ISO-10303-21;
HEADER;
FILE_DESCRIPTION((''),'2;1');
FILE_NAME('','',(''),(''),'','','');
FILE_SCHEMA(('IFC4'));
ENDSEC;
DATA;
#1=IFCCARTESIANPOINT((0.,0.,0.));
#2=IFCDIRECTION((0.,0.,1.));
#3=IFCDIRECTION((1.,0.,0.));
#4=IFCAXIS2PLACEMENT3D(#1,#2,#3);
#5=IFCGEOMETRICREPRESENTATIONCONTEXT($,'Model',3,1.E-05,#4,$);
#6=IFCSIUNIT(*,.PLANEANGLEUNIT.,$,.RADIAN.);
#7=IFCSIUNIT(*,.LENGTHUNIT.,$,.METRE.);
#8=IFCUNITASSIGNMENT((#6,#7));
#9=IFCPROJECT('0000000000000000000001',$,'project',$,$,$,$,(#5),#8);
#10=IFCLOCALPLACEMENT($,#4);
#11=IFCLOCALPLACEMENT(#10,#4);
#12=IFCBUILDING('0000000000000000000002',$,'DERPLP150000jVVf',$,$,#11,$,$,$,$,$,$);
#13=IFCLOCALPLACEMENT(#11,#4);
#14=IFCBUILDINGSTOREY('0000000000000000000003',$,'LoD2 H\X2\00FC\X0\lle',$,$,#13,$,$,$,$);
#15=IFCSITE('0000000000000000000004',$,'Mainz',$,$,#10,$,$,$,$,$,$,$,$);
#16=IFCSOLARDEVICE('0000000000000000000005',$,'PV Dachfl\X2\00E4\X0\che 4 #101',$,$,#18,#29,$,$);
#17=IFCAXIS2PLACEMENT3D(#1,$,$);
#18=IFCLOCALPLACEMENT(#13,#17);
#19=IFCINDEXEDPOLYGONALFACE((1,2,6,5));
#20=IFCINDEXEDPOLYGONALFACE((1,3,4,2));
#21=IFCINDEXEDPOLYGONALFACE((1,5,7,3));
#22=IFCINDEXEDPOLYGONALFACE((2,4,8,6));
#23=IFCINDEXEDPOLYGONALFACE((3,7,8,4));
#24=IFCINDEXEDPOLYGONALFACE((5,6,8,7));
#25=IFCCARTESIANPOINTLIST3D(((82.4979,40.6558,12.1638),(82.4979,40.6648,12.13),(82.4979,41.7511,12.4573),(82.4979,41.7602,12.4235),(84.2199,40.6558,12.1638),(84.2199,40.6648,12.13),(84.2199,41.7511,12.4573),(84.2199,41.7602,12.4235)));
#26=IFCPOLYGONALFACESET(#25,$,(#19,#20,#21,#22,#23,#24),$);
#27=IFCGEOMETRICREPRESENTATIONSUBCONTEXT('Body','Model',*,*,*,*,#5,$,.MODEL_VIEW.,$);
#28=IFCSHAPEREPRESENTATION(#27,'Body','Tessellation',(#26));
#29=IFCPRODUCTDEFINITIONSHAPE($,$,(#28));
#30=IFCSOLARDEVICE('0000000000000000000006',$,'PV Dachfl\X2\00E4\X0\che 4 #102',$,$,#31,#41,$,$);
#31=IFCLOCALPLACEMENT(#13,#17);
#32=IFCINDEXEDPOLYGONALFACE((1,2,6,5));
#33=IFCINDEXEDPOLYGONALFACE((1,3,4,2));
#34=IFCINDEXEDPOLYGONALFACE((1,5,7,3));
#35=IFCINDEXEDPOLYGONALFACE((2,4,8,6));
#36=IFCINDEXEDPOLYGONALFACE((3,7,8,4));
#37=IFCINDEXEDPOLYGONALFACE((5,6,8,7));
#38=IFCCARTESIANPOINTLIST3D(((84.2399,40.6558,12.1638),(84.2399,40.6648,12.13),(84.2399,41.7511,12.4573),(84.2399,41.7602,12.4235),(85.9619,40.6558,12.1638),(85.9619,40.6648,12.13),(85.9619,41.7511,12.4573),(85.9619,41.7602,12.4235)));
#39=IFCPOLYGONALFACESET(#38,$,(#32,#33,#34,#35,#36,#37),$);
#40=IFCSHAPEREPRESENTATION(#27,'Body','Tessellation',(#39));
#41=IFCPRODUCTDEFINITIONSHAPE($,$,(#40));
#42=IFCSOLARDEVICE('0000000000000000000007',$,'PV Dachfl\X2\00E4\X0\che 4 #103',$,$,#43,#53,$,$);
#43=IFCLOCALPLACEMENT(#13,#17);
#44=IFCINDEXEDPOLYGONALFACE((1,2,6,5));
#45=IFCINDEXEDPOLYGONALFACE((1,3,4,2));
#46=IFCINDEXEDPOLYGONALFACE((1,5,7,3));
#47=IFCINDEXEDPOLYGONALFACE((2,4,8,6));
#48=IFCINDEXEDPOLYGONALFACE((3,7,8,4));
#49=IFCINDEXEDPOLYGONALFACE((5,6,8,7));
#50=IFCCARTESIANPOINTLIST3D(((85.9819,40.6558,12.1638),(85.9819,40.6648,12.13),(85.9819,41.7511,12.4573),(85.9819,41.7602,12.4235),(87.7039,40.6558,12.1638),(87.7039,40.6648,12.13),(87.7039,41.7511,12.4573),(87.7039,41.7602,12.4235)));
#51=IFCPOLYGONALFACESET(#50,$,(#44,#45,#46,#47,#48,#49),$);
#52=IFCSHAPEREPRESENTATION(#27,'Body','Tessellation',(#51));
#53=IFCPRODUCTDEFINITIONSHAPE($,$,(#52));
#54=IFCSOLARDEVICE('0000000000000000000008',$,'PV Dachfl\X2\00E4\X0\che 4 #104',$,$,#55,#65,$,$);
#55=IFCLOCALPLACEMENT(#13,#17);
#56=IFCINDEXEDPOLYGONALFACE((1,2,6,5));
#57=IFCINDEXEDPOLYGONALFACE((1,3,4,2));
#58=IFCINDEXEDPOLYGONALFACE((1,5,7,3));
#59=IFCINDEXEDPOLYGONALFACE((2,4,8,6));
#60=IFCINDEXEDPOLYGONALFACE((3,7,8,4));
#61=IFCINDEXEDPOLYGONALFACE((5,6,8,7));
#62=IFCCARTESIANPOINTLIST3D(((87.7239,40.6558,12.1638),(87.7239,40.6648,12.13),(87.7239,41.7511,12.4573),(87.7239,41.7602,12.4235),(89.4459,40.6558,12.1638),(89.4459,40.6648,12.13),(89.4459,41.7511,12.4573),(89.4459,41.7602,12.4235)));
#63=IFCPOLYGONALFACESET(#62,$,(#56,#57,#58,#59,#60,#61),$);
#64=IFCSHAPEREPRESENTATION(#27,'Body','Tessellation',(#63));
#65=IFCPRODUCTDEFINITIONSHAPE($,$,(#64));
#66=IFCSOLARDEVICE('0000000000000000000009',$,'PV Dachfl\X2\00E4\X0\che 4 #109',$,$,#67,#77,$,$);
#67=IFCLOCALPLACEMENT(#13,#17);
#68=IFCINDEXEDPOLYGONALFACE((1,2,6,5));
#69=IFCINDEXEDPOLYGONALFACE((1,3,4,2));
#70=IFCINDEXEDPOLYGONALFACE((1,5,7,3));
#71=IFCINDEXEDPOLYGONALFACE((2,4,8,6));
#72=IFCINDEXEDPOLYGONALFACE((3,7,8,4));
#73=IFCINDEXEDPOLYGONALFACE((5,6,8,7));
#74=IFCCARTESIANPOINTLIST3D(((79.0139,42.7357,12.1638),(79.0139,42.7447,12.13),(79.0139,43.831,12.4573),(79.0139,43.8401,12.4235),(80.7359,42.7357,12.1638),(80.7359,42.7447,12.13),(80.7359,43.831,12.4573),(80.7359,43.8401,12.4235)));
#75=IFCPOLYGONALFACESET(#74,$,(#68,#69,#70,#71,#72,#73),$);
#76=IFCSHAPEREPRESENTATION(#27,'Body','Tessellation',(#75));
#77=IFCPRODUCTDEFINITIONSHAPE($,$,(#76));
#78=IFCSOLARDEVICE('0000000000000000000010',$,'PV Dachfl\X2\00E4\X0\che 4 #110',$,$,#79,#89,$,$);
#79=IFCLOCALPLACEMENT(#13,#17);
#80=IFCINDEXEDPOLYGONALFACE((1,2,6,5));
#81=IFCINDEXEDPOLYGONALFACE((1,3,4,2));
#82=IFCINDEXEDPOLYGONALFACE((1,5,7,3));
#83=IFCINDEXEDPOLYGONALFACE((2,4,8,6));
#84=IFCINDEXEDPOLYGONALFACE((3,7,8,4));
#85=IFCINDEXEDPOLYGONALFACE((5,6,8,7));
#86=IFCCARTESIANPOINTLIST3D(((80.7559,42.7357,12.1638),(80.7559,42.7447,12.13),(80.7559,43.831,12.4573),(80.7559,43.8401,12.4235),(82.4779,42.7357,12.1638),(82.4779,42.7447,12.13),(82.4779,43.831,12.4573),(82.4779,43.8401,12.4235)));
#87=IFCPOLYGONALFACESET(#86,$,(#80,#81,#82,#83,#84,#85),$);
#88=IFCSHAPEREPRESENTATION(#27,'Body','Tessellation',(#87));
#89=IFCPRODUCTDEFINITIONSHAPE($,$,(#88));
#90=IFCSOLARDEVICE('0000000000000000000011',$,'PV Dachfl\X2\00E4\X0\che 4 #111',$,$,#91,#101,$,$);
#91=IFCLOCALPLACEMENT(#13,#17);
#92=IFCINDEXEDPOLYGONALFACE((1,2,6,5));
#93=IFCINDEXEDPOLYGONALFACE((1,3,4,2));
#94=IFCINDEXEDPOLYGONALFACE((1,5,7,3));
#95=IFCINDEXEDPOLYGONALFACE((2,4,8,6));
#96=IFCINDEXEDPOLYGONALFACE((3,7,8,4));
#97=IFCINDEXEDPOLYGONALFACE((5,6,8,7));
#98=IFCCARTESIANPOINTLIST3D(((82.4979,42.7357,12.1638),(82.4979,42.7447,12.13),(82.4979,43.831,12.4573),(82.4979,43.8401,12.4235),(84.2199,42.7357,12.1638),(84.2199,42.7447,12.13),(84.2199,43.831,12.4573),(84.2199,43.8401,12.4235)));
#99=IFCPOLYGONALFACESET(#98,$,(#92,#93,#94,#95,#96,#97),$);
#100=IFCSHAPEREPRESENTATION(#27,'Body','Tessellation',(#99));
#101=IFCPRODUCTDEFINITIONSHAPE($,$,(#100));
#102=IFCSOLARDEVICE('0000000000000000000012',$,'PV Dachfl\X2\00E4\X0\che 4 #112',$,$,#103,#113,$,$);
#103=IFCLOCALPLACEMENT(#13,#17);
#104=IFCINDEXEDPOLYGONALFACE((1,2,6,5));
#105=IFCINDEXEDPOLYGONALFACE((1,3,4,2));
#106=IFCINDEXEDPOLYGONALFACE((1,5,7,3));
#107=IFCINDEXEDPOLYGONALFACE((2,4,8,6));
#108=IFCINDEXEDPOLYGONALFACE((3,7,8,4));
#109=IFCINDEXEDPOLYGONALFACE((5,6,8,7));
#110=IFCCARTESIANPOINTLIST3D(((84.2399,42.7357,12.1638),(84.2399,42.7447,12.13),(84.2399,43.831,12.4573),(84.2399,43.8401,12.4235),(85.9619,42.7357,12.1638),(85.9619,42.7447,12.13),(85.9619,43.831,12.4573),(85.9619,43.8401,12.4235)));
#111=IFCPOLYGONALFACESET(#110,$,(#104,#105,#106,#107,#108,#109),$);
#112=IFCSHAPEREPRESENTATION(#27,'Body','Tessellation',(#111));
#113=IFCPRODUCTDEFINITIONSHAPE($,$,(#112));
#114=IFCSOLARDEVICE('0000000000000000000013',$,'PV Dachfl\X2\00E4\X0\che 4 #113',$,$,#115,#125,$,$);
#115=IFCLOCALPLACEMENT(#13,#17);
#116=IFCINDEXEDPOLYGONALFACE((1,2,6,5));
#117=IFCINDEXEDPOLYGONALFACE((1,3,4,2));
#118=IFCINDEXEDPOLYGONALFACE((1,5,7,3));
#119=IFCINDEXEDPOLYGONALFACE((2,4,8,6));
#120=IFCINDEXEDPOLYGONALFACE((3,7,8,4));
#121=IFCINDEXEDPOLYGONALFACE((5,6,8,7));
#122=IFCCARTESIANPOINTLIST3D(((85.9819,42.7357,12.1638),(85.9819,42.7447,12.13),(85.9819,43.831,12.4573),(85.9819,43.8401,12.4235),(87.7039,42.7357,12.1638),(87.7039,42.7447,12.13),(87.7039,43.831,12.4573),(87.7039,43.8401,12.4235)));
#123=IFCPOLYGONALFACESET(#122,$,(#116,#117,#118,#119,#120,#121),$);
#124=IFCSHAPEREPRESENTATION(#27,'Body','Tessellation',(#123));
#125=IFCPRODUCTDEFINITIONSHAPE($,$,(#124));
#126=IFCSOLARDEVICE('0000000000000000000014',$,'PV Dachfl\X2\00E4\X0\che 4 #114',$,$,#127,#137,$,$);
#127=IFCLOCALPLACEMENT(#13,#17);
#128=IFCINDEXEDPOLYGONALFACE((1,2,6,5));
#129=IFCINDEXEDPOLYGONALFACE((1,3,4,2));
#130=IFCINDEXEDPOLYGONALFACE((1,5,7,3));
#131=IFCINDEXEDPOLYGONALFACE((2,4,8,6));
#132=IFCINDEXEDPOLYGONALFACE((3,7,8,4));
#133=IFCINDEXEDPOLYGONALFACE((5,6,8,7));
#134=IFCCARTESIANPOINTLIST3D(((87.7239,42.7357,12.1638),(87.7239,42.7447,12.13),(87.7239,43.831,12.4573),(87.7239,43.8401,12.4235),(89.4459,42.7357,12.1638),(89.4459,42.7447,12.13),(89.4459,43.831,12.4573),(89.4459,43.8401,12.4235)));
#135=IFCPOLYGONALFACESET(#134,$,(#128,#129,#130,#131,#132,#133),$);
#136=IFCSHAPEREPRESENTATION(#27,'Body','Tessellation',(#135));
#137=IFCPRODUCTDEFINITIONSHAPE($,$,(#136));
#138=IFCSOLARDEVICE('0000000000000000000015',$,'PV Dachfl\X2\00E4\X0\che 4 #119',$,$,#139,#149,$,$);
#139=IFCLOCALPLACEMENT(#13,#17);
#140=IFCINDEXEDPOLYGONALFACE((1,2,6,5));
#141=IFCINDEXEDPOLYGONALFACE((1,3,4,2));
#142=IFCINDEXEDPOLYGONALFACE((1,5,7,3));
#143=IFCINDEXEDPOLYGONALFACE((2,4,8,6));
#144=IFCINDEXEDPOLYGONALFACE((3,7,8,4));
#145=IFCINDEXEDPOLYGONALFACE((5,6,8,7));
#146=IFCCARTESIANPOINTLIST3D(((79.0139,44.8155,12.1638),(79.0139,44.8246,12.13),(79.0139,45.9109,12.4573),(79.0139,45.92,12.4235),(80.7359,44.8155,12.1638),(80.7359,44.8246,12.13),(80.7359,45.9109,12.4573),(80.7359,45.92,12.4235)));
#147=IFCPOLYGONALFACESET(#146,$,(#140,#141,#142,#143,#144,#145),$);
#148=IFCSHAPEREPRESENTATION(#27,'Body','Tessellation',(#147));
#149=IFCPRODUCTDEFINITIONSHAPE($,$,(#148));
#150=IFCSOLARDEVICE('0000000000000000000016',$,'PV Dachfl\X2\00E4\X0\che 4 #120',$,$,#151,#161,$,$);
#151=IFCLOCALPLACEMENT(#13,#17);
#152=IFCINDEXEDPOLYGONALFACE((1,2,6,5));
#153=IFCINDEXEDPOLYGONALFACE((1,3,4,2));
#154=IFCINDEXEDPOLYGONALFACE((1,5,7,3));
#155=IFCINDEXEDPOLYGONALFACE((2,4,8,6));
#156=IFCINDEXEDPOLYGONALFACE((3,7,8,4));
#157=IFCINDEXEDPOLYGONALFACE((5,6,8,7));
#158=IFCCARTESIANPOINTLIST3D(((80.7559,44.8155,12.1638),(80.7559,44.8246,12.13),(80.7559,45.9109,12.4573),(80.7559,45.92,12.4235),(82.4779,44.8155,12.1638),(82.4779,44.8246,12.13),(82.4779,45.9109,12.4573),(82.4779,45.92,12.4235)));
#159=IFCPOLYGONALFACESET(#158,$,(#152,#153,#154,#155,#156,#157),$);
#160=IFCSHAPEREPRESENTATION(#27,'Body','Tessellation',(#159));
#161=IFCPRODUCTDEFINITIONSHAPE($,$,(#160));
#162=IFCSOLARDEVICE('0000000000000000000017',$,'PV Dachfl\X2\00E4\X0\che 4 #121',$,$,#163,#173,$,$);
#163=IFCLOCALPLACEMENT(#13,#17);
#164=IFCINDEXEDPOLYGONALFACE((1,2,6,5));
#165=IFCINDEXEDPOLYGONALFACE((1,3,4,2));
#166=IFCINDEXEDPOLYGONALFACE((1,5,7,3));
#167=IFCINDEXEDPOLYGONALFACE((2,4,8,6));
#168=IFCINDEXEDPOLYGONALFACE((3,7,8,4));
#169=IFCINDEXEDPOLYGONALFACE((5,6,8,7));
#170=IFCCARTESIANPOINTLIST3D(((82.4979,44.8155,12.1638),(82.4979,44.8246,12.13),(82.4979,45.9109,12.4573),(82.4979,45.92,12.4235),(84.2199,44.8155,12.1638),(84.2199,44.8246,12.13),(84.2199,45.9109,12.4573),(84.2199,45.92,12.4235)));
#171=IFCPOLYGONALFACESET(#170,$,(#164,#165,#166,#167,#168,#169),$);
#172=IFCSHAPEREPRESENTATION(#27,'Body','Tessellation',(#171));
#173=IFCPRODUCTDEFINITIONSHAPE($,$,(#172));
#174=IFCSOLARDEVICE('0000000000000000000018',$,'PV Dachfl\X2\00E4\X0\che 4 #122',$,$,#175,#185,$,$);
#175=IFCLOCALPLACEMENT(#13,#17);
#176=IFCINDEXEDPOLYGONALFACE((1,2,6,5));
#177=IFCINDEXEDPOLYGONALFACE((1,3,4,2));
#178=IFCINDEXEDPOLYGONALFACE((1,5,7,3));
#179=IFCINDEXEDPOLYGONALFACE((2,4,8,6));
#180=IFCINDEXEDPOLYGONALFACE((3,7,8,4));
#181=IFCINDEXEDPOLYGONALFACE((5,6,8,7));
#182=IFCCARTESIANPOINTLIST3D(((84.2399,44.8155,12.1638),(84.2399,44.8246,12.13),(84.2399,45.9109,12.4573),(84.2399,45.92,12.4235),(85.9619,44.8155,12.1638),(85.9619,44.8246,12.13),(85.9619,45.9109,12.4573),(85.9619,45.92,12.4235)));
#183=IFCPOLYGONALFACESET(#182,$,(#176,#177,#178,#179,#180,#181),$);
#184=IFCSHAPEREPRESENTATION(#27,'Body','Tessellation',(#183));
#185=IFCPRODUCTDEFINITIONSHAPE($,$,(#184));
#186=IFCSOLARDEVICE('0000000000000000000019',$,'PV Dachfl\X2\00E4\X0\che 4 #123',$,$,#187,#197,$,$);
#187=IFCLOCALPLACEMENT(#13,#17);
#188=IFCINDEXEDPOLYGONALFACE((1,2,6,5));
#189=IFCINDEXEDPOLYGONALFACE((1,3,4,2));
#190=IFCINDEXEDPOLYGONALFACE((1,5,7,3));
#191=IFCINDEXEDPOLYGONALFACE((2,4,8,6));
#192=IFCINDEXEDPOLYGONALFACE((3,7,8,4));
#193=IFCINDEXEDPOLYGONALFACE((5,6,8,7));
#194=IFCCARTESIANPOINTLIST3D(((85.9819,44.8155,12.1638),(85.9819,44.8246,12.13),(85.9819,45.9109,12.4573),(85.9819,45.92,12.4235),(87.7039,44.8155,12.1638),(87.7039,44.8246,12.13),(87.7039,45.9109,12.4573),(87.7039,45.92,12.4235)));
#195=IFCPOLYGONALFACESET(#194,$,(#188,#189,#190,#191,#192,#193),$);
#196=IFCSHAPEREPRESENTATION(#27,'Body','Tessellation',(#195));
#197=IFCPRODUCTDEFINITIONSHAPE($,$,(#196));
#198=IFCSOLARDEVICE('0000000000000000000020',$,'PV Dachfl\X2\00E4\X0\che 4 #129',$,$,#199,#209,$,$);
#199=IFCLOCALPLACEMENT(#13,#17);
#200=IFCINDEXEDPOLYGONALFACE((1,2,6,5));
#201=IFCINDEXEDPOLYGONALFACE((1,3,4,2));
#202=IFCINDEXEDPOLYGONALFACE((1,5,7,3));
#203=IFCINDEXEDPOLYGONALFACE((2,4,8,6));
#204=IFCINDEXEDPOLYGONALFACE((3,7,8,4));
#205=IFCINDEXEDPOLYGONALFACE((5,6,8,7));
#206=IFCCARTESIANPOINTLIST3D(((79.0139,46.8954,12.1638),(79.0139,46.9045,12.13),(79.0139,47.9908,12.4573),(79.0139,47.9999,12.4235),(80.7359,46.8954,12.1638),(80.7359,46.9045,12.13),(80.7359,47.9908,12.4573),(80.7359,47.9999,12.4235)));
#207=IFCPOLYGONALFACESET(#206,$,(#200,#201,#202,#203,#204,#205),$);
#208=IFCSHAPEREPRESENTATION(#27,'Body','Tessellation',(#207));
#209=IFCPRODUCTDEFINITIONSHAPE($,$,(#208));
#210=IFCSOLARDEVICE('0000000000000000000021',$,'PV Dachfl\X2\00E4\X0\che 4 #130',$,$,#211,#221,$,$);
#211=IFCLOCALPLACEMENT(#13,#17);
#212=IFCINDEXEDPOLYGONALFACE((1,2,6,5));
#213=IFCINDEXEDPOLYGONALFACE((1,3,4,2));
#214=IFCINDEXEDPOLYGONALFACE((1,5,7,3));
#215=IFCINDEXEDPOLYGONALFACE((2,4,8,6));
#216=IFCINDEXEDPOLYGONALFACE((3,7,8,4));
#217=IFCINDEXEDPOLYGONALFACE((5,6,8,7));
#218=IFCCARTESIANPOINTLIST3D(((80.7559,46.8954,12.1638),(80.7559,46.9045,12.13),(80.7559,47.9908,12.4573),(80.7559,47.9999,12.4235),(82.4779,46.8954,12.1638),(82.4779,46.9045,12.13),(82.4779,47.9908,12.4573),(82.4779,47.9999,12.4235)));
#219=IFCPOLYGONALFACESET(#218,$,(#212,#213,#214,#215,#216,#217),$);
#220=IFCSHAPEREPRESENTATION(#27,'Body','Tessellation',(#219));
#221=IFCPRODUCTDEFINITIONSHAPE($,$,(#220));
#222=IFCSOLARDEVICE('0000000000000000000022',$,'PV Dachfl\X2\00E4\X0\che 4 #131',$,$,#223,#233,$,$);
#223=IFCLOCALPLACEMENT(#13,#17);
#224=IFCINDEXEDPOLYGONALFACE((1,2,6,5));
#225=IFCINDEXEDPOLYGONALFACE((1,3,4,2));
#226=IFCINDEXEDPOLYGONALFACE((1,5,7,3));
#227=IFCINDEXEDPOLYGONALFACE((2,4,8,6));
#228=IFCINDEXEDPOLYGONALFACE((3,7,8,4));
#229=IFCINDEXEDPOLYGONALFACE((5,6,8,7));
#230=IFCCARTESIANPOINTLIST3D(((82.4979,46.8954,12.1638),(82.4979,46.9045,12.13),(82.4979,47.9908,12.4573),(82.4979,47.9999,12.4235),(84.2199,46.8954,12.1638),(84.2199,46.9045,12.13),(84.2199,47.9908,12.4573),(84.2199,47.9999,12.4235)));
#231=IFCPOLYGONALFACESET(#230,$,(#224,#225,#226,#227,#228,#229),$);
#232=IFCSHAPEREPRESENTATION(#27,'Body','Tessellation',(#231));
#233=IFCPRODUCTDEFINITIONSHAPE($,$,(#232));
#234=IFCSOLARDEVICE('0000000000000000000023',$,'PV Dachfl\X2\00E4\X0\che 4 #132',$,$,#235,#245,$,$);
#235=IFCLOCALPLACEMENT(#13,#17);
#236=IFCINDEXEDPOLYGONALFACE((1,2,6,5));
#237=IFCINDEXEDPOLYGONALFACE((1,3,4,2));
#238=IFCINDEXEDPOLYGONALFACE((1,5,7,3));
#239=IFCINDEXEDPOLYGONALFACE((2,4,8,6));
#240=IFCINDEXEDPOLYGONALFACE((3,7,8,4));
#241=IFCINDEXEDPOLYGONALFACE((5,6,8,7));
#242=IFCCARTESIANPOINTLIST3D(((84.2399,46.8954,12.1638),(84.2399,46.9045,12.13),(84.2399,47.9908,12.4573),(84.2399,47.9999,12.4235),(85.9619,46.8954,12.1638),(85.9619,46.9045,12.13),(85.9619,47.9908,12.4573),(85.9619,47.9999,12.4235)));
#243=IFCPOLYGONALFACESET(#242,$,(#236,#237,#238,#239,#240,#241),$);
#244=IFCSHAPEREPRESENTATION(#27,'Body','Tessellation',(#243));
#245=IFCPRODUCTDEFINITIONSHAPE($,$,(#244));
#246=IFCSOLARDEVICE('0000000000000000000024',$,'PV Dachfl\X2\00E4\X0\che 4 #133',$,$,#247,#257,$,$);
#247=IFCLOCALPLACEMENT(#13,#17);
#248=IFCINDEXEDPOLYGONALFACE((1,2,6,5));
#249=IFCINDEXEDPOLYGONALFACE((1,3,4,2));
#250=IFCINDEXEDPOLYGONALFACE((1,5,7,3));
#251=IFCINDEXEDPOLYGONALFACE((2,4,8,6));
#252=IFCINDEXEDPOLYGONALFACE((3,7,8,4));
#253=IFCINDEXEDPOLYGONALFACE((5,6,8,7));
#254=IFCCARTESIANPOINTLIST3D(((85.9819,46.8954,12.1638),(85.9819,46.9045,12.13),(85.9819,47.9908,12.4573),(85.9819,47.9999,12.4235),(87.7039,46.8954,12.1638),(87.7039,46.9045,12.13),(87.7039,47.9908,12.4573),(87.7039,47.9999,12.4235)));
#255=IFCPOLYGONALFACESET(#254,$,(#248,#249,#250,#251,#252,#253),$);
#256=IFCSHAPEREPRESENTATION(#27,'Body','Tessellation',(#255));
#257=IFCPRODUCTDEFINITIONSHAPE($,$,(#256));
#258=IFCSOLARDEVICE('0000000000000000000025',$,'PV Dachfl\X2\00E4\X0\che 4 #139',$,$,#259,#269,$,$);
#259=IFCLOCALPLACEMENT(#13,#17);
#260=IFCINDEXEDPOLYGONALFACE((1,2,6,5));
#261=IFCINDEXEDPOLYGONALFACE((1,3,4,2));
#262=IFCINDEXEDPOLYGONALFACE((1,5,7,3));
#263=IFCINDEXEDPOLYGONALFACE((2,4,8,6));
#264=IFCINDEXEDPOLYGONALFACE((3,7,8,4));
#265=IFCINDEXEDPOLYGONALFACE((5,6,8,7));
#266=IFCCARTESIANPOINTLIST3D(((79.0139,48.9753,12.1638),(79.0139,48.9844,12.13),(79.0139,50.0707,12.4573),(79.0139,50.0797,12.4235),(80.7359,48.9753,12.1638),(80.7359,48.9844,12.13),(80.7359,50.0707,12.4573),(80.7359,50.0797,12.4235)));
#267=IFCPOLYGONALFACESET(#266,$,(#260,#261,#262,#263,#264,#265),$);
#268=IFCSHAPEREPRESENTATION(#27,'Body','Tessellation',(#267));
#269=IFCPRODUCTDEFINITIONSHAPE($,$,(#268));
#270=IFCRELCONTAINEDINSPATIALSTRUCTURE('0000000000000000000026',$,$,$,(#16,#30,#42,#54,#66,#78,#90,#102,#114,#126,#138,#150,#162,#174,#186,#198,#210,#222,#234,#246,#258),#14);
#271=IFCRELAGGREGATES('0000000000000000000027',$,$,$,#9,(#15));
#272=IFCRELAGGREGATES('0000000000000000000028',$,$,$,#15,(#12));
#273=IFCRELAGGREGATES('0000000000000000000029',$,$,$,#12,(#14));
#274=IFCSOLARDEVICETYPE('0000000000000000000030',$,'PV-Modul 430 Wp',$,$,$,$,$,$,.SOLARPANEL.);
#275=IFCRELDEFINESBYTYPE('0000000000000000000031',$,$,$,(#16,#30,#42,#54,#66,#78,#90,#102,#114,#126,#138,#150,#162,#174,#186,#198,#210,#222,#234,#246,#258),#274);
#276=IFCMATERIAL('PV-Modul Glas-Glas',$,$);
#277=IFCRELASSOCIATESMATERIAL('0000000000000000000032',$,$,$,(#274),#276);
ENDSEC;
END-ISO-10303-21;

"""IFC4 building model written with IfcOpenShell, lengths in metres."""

from ifc_helpers import new_model, si_unit, frame, frame_2d, origin, origin_with_axes, place, context, subcontext, project, spatial, rectangle, extrude, source, transform, mapped, material, type_object, type_shapes, element, save


model = new_model("IFC4")

# Units and contexts
model_context = context("Model", 3, precision=1e-05, world=origin_with_axes())
body_context = subcontext(model_context, "Body", "Model", "MODEL_VIEW")
ifc_project = project(units=[si_unit("PLANEANGLEUNIT", "RADIAN"), si_unit("LENGTHUNIT", "METRE")], contexts=[model_context])

# Site, building, storey
site_placement = place(None, origin_with_axes())
site = spatial("IfcSite", under=ifc_project, at=site_placement, Name="Mainz")
building_placement = place(site_placement, origin_with_axes())
building = spatial("IfcBuilding", under=site, at=building_placement, Name="DERPLP150000jVVf")
storey_placement = place(building_placement, origin_with_axes())
storey = spatial("IfcBuildingStorey", under=building, at=storey_placement, Name="LoD2 Hülle")

# Solar devices
ifc_material = material(Name="PV-Modul Glas-Glas")
solar_device_type = type_object("IfcSolarDeviceType", Name="PV-Modul 430 Wp", PredefinedType="SOLARPANEL", material=ifc_material)
shared_shape = source(origin_with_axes(), body_context, "Body", "SweptSolid", [
    extrude(rectangle(XDim=1.722, YDim=1.134, at=frame_2d((0.861, 0.567))), origin(), (0.0, 0.0, 1.0), 0.035),
])
type_shapes(solar_device_type, [shared_shape])
for number, where, z_axis, x_axis, name in (
    (1, (82.4979, 40.6648, 12.13), (0.0, -0.258819, 0.965926), (1.0, 0.0, 0.0), "PV Dachfläche 4 #101"),
    (2, (84.2399, 40.6648, 12.13), (0.0, -0.258819, 0.965926), (1.0, 0.0, 0.0), "PV Dachfläche 4 #102"),
    (3, (85.9819, 40.6648, 12.13), (0.0, -0.258819, 0.965926), (1.0, 0.0, 0.0), "PV Dachfläche 4 #103"),
    (4, (87.7239, 40.6648, 12.13), (0.0, -0.258819, 0.965926), (1.0, 0.0, 0.0), "PV Dachfläche 4 #104"),
    (5, (79.0139, 42.7447, 12.13), (0.0, -0.258819, 0.965926), (1.0, 0.0, 0.0), "PV Dachfläche 4 #109"),
    (6, (80.7559, 42.7447, 12.13), (0.0, -0.258819, 0.965926), (1.0, 0.0, 0.0), "PV Dachfläche 4 #110"),
    (7, (82.4979, 42.7447, 12.13), (0.0, -0.258819, 0.965926), (1.0, 0.0, 0.0), "PV Dachfläche 4 #111"),
    (8, (84.2399, 42.7447, 12.13), (0.0, -0.258819, 0.965926), (1.0, 0.0, 0.0), "PV Dachfläche 4 #112"),
    (9, (85.9819, 42.7447, 12.13), (0.0, -0.258819, 0.965926), (1.0, 0.0, 0.0), "PV Dachfläche 4 #113"),
    (10, (87.7239, 42.7447, 12.13), (0.0, -0.258819, 0.965926), (1.0, 0.0, 0.0), "PV Dachfläche 4 #114"),
    (11, (79.0139, 44.8246, 12.13), (0.0, -0.258819, 0.965926), (1.0, 0.0, 0.0), "PV Dachfläche 4 #119"),
    (12, (80.7559, 44.8246, 12.13), (0.0, -0.258819, 0.965926), (1.0, 0.0, 0.0), "PV Dachfläche 4 #120"),
    (13, (82.4979, 44.8246, 12.13), (0.0, -0.258819, 0.965926), (1.0, 0.0, 0.0), "PV Dachfläche 4 #121"),
    (14, (84.2399, 44.8246, 12.13), (0.0, -0.258819, 0.965926), (1.0, 0.0, 0.0), "PV Dachfläche 4 #122"),
    (15, (85.9819, 44.8246, 12.13), (0.0, -0.258819, 0.965926), (1.0, 0.0, 0.0), "PV Dachfläche 4 #123"),
    (16, (79.0139, 46.9045, 12.13), (0.0, -0.258819, 0.965926), (1.0, 0.0, 0.0), "PV Dachfläche 4 #129"),
    (17, (80.7559, 46.9045, 12.13), (0.0, -0.258819, 0.965926), (1.0, 0.0, 0.0), "PV Dachfläche 4 #130"),
    (18, (82.4979, 46.9045, 12.13), (0.0, -0.258819, 0.965926), (1.0, 0.0, 0.0), "PV Dachfläche 4 #131"),
    (19, (84.2399, 46.9045, 12.13), (0.0, -0.258819, 0.965926), (1.0, 0.0, 0.0), "PV Dachfläche 4 #132"),
    (20, (85.9819, 46.9045, 12.13), (0.0, -0.258819, 0.965926), (1.0, 0.0, 0.0), "PV Dachfläche 4 #133"),
    (21, (79.0139, 48.9844, 12.13), (0.0, -0.258819, 0.965926), (1.0, 0.0, 0.0), "PV Dachfläche 4 #139"),
):
    element("IfcSolarDevice", number, at=place(storey_placement, frame(where, z_axis=z_axis, x_axis=x_axis)), inside=storey, type_object=solar_device_type, Name=name, context=body_context, shape_type="MappedRepresentation", body=[
        mapped(shared_shape, transform((0.0, 0.0, 0.0), x_axis=(1.0, 0.0, 0.0), y_axis=(0.0, 1.0, 0.0), z_axis=(0.0, 0.0, 1.0), scale=1.0)),
    ])

save(model, "model.ifc")
